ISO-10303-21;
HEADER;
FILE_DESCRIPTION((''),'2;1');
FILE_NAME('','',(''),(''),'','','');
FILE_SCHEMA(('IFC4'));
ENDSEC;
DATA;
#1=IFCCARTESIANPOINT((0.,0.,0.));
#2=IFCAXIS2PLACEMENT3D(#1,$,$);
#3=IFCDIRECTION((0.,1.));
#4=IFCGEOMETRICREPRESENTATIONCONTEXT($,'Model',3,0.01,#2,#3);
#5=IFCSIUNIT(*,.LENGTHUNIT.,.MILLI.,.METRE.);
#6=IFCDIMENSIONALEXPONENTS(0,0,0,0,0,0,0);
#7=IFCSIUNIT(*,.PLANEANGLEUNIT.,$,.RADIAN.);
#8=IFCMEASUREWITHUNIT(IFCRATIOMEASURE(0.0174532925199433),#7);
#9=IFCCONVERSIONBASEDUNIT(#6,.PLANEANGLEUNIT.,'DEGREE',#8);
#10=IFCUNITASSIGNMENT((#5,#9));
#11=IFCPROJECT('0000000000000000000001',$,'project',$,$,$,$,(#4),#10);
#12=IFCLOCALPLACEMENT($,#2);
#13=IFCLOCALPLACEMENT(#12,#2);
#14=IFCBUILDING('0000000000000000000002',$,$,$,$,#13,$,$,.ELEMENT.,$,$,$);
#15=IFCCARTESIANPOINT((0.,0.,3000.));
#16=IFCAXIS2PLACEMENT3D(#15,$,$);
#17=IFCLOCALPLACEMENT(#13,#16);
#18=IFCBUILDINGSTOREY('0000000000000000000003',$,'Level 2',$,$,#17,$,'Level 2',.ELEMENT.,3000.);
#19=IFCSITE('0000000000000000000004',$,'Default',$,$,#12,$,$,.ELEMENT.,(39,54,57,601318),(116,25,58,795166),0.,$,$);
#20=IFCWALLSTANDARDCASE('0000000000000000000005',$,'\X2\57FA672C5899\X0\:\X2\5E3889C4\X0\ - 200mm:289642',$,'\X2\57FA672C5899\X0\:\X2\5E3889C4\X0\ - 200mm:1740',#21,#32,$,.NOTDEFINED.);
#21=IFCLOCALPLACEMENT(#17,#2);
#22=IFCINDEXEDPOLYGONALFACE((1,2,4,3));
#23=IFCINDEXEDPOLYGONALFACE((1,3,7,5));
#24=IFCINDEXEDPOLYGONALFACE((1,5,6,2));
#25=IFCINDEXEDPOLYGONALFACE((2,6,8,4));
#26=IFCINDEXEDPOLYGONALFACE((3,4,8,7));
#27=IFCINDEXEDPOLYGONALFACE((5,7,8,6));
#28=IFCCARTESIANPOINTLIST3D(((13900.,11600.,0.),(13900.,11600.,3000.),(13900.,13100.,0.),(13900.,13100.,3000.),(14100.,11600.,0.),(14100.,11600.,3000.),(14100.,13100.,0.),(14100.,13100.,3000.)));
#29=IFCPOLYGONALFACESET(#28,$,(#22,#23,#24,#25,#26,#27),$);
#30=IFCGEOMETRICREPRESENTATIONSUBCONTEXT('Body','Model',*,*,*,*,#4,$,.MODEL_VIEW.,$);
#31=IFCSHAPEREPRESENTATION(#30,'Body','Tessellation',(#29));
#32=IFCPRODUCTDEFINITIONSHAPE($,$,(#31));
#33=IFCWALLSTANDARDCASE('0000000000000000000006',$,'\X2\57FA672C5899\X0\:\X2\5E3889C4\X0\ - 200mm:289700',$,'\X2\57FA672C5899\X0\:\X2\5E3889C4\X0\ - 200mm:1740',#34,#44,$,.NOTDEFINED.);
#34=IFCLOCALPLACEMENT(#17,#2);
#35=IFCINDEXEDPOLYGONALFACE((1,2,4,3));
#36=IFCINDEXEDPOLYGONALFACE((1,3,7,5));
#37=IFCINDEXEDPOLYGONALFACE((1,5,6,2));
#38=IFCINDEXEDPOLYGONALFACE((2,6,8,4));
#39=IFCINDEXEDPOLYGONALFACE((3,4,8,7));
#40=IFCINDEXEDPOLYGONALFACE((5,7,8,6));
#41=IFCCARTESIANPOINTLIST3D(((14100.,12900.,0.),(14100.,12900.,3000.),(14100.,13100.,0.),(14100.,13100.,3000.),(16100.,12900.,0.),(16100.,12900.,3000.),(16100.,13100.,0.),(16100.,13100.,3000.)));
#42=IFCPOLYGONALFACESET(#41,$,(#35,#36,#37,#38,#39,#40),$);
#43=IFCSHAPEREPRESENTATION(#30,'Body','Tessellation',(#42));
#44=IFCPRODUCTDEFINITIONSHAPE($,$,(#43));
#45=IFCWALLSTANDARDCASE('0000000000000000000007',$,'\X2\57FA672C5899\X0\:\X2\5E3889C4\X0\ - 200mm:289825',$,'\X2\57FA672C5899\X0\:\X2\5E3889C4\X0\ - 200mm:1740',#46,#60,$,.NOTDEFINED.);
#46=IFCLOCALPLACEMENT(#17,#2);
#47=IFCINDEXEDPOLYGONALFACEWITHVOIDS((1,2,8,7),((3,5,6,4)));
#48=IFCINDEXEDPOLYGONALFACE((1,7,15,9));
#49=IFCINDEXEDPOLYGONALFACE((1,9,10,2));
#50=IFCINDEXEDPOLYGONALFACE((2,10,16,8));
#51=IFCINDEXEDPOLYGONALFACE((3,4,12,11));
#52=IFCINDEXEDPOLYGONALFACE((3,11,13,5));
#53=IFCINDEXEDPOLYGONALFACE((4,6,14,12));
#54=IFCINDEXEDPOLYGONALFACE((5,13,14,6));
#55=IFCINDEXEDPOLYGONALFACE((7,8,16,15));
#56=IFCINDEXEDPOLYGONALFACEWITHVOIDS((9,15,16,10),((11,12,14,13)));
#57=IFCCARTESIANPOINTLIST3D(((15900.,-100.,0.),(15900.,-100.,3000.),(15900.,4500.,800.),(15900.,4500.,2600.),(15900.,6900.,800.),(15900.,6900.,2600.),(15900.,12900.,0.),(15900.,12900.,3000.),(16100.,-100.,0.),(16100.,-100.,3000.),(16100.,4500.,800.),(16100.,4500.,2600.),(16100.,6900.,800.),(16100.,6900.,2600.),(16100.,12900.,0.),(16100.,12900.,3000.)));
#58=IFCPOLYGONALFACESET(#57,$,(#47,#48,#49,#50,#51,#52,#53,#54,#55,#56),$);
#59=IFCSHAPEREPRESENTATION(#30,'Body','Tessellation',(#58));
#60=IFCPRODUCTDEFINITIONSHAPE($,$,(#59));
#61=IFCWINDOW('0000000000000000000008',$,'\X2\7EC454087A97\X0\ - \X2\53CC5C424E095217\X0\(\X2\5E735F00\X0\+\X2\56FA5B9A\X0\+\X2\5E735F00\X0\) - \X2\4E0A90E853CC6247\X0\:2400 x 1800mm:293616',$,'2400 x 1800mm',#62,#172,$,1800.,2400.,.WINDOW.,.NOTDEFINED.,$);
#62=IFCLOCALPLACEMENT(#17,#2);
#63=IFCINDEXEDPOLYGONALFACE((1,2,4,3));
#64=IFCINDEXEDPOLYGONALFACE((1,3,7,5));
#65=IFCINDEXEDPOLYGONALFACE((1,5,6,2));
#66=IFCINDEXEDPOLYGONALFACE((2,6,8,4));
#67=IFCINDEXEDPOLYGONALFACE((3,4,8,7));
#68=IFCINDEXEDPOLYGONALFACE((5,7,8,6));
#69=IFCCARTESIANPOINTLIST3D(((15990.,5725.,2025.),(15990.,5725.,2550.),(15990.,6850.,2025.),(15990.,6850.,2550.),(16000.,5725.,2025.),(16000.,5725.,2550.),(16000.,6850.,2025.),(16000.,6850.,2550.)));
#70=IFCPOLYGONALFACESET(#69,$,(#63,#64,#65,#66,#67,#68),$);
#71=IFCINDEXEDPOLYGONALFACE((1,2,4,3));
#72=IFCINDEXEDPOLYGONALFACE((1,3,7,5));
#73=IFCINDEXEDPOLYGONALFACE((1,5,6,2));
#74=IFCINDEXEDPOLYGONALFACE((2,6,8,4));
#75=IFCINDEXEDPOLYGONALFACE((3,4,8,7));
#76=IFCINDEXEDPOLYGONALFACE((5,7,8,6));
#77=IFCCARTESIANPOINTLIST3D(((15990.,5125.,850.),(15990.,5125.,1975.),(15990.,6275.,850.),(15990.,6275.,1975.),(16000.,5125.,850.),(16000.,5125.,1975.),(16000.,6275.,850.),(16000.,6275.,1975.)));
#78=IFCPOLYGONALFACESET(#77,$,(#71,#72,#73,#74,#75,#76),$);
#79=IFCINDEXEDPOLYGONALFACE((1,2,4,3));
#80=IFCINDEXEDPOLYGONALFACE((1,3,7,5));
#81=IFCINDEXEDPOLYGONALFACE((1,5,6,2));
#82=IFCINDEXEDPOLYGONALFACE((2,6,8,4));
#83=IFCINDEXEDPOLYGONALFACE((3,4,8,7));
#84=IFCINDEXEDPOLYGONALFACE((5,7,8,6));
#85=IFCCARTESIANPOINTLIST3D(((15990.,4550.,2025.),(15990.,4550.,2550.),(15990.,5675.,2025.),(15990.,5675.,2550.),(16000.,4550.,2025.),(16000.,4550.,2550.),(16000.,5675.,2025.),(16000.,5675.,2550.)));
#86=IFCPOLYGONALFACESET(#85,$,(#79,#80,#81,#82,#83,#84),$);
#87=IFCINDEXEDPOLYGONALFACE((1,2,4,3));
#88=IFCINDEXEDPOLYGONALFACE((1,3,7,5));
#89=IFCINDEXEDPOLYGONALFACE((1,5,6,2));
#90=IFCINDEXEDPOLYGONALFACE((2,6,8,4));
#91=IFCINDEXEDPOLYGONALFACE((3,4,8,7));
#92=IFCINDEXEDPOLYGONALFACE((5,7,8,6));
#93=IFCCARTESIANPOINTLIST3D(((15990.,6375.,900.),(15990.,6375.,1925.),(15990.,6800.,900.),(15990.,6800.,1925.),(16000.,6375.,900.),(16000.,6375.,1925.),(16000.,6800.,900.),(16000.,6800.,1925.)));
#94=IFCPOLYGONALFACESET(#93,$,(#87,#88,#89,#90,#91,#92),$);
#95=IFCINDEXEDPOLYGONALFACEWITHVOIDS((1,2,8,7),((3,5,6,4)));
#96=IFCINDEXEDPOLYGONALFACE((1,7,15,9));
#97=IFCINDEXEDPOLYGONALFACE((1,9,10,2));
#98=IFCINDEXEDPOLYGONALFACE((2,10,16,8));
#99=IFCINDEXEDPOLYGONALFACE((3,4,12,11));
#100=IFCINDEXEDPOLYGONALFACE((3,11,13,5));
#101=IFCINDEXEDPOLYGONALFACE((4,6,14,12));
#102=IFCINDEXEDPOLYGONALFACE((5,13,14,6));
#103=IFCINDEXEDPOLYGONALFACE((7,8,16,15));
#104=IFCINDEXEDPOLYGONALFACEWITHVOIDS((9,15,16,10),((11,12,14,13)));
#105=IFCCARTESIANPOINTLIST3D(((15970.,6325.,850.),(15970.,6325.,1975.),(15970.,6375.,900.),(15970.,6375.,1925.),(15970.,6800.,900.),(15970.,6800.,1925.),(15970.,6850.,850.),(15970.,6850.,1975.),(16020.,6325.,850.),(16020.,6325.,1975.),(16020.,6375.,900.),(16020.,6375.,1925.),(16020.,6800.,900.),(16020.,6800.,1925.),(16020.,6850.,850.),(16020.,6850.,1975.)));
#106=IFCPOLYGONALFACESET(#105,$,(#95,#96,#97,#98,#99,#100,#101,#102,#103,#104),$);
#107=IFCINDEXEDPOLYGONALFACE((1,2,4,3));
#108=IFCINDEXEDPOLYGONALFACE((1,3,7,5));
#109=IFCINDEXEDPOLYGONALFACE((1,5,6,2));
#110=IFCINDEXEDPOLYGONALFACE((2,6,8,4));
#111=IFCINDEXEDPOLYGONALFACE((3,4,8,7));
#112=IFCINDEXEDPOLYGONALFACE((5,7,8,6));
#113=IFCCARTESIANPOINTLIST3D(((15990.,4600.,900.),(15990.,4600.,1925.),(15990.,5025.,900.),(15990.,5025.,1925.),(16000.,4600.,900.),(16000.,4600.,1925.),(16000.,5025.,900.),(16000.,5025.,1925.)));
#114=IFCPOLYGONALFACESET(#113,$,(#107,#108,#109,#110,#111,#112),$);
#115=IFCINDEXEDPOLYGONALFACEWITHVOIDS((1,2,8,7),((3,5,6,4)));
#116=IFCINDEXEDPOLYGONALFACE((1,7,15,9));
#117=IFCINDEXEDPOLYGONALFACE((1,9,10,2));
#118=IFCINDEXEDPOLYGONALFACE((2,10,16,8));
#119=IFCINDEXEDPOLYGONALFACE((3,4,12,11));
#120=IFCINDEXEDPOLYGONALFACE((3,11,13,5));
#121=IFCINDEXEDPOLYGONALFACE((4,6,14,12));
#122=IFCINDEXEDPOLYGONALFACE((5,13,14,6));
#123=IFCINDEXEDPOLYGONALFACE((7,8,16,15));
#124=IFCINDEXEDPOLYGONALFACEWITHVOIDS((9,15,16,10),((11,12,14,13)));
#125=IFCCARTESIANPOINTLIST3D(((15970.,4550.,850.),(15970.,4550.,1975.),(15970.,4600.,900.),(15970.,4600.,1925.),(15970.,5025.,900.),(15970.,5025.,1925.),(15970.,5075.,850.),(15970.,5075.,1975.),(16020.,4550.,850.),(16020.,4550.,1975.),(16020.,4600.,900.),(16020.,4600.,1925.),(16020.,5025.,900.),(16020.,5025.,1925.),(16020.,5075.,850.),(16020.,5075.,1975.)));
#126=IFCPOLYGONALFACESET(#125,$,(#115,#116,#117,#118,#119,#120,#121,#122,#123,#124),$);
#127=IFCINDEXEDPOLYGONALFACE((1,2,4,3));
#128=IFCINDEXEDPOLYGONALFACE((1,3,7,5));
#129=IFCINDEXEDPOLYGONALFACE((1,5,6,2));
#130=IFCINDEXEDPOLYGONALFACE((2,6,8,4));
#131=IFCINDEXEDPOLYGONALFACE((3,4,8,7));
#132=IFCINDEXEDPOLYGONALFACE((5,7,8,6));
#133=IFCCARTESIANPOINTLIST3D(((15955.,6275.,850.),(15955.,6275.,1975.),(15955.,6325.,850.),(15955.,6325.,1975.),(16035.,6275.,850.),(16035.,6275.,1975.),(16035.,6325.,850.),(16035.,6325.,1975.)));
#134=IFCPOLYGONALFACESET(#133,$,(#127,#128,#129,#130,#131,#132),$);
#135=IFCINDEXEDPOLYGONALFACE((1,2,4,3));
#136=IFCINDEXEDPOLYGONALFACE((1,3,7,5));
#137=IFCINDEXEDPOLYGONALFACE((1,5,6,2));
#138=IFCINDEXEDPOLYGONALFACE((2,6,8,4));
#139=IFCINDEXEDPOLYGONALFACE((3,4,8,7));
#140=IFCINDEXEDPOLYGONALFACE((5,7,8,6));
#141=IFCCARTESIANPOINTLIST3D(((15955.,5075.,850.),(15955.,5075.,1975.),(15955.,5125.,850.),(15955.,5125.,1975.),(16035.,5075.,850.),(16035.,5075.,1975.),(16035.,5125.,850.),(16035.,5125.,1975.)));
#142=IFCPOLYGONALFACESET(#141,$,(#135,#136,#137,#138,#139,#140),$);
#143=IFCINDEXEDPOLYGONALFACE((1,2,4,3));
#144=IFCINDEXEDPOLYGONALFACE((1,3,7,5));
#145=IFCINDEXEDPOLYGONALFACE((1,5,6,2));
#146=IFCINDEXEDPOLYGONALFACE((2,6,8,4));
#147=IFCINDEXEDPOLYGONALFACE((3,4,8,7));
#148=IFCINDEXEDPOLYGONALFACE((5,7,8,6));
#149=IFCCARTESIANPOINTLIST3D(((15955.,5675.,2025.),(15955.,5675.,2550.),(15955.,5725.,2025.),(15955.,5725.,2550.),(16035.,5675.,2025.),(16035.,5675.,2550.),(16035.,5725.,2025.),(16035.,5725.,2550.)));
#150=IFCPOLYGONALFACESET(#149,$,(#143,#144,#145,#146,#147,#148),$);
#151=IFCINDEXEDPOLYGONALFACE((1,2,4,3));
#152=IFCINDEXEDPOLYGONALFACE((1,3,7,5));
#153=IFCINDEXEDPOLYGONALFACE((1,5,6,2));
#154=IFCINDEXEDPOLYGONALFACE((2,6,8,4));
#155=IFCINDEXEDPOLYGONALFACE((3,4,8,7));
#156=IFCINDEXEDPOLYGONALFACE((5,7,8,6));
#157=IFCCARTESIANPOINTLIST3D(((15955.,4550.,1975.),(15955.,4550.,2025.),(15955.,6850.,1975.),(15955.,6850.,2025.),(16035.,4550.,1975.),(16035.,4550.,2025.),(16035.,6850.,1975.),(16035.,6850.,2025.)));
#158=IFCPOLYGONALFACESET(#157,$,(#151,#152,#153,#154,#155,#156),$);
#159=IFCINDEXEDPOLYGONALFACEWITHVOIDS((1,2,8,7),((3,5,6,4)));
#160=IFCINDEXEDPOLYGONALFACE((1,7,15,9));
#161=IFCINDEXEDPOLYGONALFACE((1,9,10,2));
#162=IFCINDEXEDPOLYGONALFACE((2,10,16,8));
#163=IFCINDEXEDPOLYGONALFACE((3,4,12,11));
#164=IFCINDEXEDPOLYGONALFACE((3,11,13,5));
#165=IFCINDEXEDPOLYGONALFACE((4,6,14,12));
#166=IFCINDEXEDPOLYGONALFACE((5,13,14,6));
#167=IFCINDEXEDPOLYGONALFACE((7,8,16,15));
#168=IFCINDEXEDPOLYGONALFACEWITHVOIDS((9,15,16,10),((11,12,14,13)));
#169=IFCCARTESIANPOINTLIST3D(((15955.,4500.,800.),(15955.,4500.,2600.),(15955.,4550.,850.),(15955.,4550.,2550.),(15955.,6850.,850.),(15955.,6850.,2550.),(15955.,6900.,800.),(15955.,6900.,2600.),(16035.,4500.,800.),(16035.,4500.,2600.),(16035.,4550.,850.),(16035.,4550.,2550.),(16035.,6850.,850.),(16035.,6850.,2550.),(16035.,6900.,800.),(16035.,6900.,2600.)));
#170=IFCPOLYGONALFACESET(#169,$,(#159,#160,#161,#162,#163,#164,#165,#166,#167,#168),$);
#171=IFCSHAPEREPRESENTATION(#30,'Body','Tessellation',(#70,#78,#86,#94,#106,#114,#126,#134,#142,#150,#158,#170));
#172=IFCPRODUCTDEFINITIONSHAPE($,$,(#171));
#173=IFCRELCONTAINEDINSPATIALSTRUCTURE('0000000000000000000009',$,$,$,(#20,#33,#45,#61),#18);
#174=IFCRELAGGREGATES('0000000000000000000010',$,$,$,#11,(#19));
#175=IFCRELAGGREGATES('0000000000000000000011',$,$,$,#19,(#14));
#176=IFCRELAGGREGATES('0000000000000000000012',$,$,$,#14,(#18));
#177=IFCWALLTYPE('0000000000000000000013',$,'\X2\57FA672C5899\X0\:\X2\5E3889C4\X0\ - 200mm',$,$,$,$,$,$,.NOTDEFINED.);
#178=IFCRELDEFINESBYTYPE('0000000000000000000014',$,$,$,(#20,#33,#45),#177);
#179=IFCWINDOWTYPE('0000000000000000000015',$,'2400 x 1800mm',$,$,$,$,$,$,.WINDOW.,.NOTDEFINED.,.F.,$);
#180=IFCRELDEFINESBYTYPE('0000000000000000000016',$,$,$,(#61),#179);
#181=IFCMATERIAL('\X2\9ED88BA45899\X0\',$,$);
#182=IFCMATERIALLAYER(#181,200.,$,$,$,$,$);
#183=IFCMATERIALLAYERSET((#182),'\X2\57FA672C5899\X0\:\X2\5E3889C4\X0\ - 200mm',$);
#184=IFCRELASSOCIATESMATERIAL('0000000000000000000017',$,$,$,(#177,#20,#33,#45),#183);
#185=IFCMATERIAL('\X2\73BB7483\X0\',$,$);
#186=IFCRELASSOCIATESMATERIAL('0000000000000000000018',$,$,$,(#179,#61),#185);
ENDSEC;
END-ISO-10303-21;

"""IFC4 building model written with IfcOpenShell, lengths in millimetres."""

from ifc_helpers import new_model, entity, si_unit, converted_unit, direction, frame, frame_2d, origin, origin_2d_with_axis, place, context, subcontext, project, spatial, polyline, rectangle, outline, extrude, source, transform, mapped, material, layer, layer_set, layer_usage, type_object, type_shapes, element, fill, save


model = new_model("IFC4")

# Units and contexts
model_context = context("Model", 3, precision=0.01, world=origin(), true_north=direction((0.0, 1.0)))
body_context = subcontext(model_context, "Body", "Model", "MODEL_VIEW")
ifc_project = project(units=[si_unit("LENGTHUNIT", "METRE", prefix="MILLI"), converted_unit("PLANEANGLEUNIT", "DEGREE", entity("IfcRatioMeasure", 0.0174532925199433), si_unit("PLANEANGLEUNIT", "RADIAN"), dimensions=[0, 0, 0, 0, 0, 0, 0])], contexts=[model_context])

# Site, building, storey
site_placement = place(None, origin())
site = spatial("IfcSite", under=ifc_project, at=site_placement, Name="Default", CompositionType="ELEMENT", RefLatitude=(39, 54, 57, 601318), RefLongitude=(116, 25, 58, 795166), RefElevation=0.0)
building_placement = place(site_placement, origin())
building = spatial("IfcBuilding", under=site, at=building_placement, CompositionType="ELEMENT")
storey_placement = place(building_placement, frame((0.0, 0.0, 3000.0)))
storey = spatial("IfcBuildingStorey", under=building, at=storey_placement, Name="Level 2", LongName="Level 2", CompositionType="ELEMENT", Elevation=3000.0)

# Shared definitions
ifc_material_1 = material(Name="默认墙")
ifc_layer = layer(ifc_material_1, 200.0)
ifc_layer_set = layer_set([ifc_layer], Name="基本墙:常规 - 200mm")
wall_type = type_object("IfcWallType", Name="基本墙:常规 - 200mm", PredefinedType="NOTDEFINED", material=ifc_layer_set)

# Walls
ifc_layer_usage_1 = layer_usage(ifc_layer_set, "AXIS2", "NEGATIVE", 100.0)
wall_1_placement = place(storey_placement, frame((14000.0, 11600.0, 0.0), z_axis=(0.0, 0.0, 1.0), x_axis=(0.0, 1.0, 0.0)))
element("IfcWallStandardCase", 1, at=wall_1_placement, inside=storey, type_object=wall_type, material=ifc_layer_usage_1, Name="基本墙:常规 - 200mm:289642", ObjectType="基本墙:常规 - 200mm:1740", PredefinedType="NOTDEFINED", context=body_context, shape_type="SweptSolid", body=[
    extrude(rectangle(XDim=1500.0, YDim=200.0, at=frame_2d((750.0, 0.0), x_axis=(-1.0, 0.0))), origin(), (0.0, 0.0, 1.0), 3000.0),
])
ifc_layer_usage_2 = layer_usage(ifc_layer_set, "AXIS2", "NEGATIVE", 100.0)
wall_2_placement = place(storey_placement, frame((14100.0, 13000.0, 0.0)))
element("IfcWallStandardCase", 2, at=wall_2_placement, inside=storey, type_object=wall_type, material=ifc_layer_usage_2, Name="基本墙:常规 - 200mm:289700", ObjectType="基本墙:常规 - 200mm:1740", PredefinedType="NOTDEFINED", context=body_context, shape_type="SweptSolid", body=[
    extrude(rectangle(XDim=2000.0, YDim=200.0, at=frame_2d((1000.0, 0.0), x_axis=(-1.0, 0.0))), origin(), (0.0, 0.0, 1.0), 3000.0),
])

# Wall, opening, window
ifc_layer_usage_3 = layer_usage(ifc_layer_set, "AXIS2", "NEGATIVE", 100.0)
wall_3_placement = place(storey_placement, frame((16000.0, 12900.0, 0.0), z_axis=(0.0, 0.0, 1.0), x_axis=(0.0, -1.0, 0.0)))
wall_3 = element("IfcWallStandardCase", 3, at=wall_3_placement, inside=storey, type_object=wall_type, material=ifc_layer_usage_3, Name="基本墙:常规 - 200mm:289825", ObjectType="基本墙:常规 - 200mm:1740", PredefinedType="NOTDEFINED", context=body_context, shape_type="SweptSolid", body=[
    extrude(rectangle(XDim=13000.0, YDim=200.0, at=frame_2d((6500.0, 0.0), x_axis=(-1.0, 0.0))), origin(), (0.0, 0.0, 1.0), 3000.0),
])
opening_1_placement = place(wall_3_placement, frame((6000.0, -100.0, 800.0)))
opening_1 = element("IfcOpeningElement", 4, at=opening_1_placement, cuts=wall_3, ObjectType="Opening", PredefinedType="OPENING", context=body_context, shape_type="SweptSolid", body=[
    extrude(rectangle(XDim=1800.0, YDim=2400.0, at=frame_2d((900.0, 1200.0), x_axis=(1.0, 0.0))), frame((0.0, 0.0, 0.0), z_axis=(0.0, 1.0, 0.0), x_axis=(0.0, 0.0, 1.0)), (0.0, 0.0, 1.0), 200.0),
])
ifc_material_2 = material(Name="玻璃")
window_type_1 = type_object("IfcWindowType", Name="2400 x 1800mm", ParameterTakesPrecedence=False, PartitioningType="NOTDEFINED", PredefinedType="WINDOW", material=ifc_material_2)
shared_shape_1 = source(origin(), body_context, "Body", "SweptSolid", [
    extrude(rectangle(XDim=10.0, YDim=1125.0, at=origin_2d_with_axis()), frame((612.5, 95.0, 1225.0), z_axis=(0.0, 0.0, 1.0), x_axis=(0.0, 1.0, 0.0)), (0.0, 0.0, 1.0), 525.0),
    extrude(rectangle(XDim=10.0, YDim=1150.0, at=origin_2d_with_axis()), frame((1200.0, 95.0, 50.0), z_axis=(0.0, 0.0, 1.0), x_axis=(0.0, 1.0, 0.0)), (0.0, 0.0, 1.0), 1125.0),
    extrude(rectangle(XDim=10.0, YDim=1125.0, at=origin_2d_with_axis()), frame((1787.5, 95.0, 1225.0), z_axis=(0.0, 0.0, 1.0), x_axis=(0.0, 1.0, 0.0)), (0.0, 0.0, 1.0), 525.0),
    extrude(rectangle(XDim=10.0, YDim=425.0, at=origin_2d_with_axis()), frame((312.5, 95.0, 100.0), z_axis=(0.0, 0.0, 1.0), x_axis=(0.0, 1.0, 0.0)), (0.0, 0.0, 1.0), 1025.0),
    extrude(outline(polyline([(-562.5, -262.5), (562.5, -262.5), (562.5, 262.5), (-562.5, 262.5), (-562.5, -262.5)]), holes=[polyline([(512.5, -212.5), (-512.5, -212.5), (-512.5, 212.5), (512.5, 212.5), (512.5, -212.5)])]), frame((312.5, 70.0, 612.5), z_axis=(0.0, 1.0, 0.0), x_axis=(0.0, 0.0, -1.0)), (0.0, 0.0, 1.0), 50.0),
    extrude(rectangle(XDim=10.0, YDim=425.0, at=frame_2d((0.0, 0.0), x_axis=(1.0, 0.0))), frame((2087.5, 95.0, 100.0), z_axis=(0.0, 0.0, 1.0), x_axis=(0.0, 1.0, 0.0)), (0.0, 0.0, 1.0), 1025.0),
    extrude(outline(polyline([(-562.5, -262.5), (562.5, -262.5), (562.5, 262.5), (-562.5, 262.5), (-562.5, -262.5)]), holes=[polyline([(512.5, -212.5), (-512.5, -212.5), (-512.5, 212.5), (512.5, 212.5), (512.5, -212.5)])]), frame((2087.5, 70.0, 612.5), z_axis=(0.0, 1.0, 0.0), x_axis=(0.0, 0.0, -1.0)), (0.0, 0.0, 1.0), 50.0),
    extrude(rectangle(XDim=80.0, YDim=50.0, at=origin_2d_with_axis()), frame((600.0, 95.0, 50.0), z_axis=(0.0, 0.0, 1.0), x_axis=(0.0, -1.0, 0.0)), (0.0, 0.0, 1.0), 1125.0),
    extrude(rectangle(XDim=80.0, YDim=50.0, at=origin_2d_with_axis()), frame((1800.0, 95.0, 50.0), z_axis=(0.0, 0.0, 1.0), x_axis=(0.0, -1.0, 0.0)), (0.0, 0.0, 1.0), 1125.0),
    extrude(rectangle(XDim=80.0, YDim=50.0, at=frame_2d((0.0, 0.0), x_axis=(1.0, 0.0))), frame((1200.0, 95.0, 1225.0), z_axis=(0.0, 0.0, 1.0), x_axis=(0.0, -1.0, 0.0)), (0.0, 0.0, 1.0), 525.0),
    extrude(rectangle(XDim=80.0, YDim=2300.0, at=frame_2d((0.0, 0.0), x_axis=(1.0, 0.0))), frame((1200.0, 95.0, 1175.0), z_axis=(0.0, 0.0, 1.0), x_axis=(0.0, -1.0, 0.0)), (0.0, 0.0, 1.0), 50.0),
    extrude(outline(polyline([(-1200.0, -900.0), (1200.0, -900.0), (1200.0, 900.0), (-1200.0, 900.0), (-1200.0, -900.0)]), holes=[polyline([(1150.0, -850.0), (-1150.0, -850.0), (-1150.0, 850.0), (1150.0, 850.0), (1150.0, -850.0)])]), frame((1200.0, 55.0, 900.0), z_axis=(0.0, 1.0, 0.0), x_axis=(1.0, 0.0, 0.0)), (0.0, 0.0, 1.0), 80.0),
])
type_shapes(window_type_1, [shared_shape_1])
window_1_placement = place(opening_1_placement, origin())
window_1 = element("IfcWindow", 5, at=window_1_placement, inside=storey, type_object=window_type_1, material=ifc_material_2, Name="组合窗 - 双层三列(平开+固定+平开) - 上部双扇:2400 x 1800mm:293616", ObjectType="2400 x 1800mm", OverallHeight=1800.0, OverallWidth=2400.0, PartitioningType="NOTDEFINED", PredefinedType="WINDOW", context=body_context, shape_type="MappedRepresentation", body=[
    mapped(shared_shape_1, transform((0.0, 0.0, 0.0), scale=1.0)),
])
fill(opening_1, window_1)

save(model, "model.ifc")
